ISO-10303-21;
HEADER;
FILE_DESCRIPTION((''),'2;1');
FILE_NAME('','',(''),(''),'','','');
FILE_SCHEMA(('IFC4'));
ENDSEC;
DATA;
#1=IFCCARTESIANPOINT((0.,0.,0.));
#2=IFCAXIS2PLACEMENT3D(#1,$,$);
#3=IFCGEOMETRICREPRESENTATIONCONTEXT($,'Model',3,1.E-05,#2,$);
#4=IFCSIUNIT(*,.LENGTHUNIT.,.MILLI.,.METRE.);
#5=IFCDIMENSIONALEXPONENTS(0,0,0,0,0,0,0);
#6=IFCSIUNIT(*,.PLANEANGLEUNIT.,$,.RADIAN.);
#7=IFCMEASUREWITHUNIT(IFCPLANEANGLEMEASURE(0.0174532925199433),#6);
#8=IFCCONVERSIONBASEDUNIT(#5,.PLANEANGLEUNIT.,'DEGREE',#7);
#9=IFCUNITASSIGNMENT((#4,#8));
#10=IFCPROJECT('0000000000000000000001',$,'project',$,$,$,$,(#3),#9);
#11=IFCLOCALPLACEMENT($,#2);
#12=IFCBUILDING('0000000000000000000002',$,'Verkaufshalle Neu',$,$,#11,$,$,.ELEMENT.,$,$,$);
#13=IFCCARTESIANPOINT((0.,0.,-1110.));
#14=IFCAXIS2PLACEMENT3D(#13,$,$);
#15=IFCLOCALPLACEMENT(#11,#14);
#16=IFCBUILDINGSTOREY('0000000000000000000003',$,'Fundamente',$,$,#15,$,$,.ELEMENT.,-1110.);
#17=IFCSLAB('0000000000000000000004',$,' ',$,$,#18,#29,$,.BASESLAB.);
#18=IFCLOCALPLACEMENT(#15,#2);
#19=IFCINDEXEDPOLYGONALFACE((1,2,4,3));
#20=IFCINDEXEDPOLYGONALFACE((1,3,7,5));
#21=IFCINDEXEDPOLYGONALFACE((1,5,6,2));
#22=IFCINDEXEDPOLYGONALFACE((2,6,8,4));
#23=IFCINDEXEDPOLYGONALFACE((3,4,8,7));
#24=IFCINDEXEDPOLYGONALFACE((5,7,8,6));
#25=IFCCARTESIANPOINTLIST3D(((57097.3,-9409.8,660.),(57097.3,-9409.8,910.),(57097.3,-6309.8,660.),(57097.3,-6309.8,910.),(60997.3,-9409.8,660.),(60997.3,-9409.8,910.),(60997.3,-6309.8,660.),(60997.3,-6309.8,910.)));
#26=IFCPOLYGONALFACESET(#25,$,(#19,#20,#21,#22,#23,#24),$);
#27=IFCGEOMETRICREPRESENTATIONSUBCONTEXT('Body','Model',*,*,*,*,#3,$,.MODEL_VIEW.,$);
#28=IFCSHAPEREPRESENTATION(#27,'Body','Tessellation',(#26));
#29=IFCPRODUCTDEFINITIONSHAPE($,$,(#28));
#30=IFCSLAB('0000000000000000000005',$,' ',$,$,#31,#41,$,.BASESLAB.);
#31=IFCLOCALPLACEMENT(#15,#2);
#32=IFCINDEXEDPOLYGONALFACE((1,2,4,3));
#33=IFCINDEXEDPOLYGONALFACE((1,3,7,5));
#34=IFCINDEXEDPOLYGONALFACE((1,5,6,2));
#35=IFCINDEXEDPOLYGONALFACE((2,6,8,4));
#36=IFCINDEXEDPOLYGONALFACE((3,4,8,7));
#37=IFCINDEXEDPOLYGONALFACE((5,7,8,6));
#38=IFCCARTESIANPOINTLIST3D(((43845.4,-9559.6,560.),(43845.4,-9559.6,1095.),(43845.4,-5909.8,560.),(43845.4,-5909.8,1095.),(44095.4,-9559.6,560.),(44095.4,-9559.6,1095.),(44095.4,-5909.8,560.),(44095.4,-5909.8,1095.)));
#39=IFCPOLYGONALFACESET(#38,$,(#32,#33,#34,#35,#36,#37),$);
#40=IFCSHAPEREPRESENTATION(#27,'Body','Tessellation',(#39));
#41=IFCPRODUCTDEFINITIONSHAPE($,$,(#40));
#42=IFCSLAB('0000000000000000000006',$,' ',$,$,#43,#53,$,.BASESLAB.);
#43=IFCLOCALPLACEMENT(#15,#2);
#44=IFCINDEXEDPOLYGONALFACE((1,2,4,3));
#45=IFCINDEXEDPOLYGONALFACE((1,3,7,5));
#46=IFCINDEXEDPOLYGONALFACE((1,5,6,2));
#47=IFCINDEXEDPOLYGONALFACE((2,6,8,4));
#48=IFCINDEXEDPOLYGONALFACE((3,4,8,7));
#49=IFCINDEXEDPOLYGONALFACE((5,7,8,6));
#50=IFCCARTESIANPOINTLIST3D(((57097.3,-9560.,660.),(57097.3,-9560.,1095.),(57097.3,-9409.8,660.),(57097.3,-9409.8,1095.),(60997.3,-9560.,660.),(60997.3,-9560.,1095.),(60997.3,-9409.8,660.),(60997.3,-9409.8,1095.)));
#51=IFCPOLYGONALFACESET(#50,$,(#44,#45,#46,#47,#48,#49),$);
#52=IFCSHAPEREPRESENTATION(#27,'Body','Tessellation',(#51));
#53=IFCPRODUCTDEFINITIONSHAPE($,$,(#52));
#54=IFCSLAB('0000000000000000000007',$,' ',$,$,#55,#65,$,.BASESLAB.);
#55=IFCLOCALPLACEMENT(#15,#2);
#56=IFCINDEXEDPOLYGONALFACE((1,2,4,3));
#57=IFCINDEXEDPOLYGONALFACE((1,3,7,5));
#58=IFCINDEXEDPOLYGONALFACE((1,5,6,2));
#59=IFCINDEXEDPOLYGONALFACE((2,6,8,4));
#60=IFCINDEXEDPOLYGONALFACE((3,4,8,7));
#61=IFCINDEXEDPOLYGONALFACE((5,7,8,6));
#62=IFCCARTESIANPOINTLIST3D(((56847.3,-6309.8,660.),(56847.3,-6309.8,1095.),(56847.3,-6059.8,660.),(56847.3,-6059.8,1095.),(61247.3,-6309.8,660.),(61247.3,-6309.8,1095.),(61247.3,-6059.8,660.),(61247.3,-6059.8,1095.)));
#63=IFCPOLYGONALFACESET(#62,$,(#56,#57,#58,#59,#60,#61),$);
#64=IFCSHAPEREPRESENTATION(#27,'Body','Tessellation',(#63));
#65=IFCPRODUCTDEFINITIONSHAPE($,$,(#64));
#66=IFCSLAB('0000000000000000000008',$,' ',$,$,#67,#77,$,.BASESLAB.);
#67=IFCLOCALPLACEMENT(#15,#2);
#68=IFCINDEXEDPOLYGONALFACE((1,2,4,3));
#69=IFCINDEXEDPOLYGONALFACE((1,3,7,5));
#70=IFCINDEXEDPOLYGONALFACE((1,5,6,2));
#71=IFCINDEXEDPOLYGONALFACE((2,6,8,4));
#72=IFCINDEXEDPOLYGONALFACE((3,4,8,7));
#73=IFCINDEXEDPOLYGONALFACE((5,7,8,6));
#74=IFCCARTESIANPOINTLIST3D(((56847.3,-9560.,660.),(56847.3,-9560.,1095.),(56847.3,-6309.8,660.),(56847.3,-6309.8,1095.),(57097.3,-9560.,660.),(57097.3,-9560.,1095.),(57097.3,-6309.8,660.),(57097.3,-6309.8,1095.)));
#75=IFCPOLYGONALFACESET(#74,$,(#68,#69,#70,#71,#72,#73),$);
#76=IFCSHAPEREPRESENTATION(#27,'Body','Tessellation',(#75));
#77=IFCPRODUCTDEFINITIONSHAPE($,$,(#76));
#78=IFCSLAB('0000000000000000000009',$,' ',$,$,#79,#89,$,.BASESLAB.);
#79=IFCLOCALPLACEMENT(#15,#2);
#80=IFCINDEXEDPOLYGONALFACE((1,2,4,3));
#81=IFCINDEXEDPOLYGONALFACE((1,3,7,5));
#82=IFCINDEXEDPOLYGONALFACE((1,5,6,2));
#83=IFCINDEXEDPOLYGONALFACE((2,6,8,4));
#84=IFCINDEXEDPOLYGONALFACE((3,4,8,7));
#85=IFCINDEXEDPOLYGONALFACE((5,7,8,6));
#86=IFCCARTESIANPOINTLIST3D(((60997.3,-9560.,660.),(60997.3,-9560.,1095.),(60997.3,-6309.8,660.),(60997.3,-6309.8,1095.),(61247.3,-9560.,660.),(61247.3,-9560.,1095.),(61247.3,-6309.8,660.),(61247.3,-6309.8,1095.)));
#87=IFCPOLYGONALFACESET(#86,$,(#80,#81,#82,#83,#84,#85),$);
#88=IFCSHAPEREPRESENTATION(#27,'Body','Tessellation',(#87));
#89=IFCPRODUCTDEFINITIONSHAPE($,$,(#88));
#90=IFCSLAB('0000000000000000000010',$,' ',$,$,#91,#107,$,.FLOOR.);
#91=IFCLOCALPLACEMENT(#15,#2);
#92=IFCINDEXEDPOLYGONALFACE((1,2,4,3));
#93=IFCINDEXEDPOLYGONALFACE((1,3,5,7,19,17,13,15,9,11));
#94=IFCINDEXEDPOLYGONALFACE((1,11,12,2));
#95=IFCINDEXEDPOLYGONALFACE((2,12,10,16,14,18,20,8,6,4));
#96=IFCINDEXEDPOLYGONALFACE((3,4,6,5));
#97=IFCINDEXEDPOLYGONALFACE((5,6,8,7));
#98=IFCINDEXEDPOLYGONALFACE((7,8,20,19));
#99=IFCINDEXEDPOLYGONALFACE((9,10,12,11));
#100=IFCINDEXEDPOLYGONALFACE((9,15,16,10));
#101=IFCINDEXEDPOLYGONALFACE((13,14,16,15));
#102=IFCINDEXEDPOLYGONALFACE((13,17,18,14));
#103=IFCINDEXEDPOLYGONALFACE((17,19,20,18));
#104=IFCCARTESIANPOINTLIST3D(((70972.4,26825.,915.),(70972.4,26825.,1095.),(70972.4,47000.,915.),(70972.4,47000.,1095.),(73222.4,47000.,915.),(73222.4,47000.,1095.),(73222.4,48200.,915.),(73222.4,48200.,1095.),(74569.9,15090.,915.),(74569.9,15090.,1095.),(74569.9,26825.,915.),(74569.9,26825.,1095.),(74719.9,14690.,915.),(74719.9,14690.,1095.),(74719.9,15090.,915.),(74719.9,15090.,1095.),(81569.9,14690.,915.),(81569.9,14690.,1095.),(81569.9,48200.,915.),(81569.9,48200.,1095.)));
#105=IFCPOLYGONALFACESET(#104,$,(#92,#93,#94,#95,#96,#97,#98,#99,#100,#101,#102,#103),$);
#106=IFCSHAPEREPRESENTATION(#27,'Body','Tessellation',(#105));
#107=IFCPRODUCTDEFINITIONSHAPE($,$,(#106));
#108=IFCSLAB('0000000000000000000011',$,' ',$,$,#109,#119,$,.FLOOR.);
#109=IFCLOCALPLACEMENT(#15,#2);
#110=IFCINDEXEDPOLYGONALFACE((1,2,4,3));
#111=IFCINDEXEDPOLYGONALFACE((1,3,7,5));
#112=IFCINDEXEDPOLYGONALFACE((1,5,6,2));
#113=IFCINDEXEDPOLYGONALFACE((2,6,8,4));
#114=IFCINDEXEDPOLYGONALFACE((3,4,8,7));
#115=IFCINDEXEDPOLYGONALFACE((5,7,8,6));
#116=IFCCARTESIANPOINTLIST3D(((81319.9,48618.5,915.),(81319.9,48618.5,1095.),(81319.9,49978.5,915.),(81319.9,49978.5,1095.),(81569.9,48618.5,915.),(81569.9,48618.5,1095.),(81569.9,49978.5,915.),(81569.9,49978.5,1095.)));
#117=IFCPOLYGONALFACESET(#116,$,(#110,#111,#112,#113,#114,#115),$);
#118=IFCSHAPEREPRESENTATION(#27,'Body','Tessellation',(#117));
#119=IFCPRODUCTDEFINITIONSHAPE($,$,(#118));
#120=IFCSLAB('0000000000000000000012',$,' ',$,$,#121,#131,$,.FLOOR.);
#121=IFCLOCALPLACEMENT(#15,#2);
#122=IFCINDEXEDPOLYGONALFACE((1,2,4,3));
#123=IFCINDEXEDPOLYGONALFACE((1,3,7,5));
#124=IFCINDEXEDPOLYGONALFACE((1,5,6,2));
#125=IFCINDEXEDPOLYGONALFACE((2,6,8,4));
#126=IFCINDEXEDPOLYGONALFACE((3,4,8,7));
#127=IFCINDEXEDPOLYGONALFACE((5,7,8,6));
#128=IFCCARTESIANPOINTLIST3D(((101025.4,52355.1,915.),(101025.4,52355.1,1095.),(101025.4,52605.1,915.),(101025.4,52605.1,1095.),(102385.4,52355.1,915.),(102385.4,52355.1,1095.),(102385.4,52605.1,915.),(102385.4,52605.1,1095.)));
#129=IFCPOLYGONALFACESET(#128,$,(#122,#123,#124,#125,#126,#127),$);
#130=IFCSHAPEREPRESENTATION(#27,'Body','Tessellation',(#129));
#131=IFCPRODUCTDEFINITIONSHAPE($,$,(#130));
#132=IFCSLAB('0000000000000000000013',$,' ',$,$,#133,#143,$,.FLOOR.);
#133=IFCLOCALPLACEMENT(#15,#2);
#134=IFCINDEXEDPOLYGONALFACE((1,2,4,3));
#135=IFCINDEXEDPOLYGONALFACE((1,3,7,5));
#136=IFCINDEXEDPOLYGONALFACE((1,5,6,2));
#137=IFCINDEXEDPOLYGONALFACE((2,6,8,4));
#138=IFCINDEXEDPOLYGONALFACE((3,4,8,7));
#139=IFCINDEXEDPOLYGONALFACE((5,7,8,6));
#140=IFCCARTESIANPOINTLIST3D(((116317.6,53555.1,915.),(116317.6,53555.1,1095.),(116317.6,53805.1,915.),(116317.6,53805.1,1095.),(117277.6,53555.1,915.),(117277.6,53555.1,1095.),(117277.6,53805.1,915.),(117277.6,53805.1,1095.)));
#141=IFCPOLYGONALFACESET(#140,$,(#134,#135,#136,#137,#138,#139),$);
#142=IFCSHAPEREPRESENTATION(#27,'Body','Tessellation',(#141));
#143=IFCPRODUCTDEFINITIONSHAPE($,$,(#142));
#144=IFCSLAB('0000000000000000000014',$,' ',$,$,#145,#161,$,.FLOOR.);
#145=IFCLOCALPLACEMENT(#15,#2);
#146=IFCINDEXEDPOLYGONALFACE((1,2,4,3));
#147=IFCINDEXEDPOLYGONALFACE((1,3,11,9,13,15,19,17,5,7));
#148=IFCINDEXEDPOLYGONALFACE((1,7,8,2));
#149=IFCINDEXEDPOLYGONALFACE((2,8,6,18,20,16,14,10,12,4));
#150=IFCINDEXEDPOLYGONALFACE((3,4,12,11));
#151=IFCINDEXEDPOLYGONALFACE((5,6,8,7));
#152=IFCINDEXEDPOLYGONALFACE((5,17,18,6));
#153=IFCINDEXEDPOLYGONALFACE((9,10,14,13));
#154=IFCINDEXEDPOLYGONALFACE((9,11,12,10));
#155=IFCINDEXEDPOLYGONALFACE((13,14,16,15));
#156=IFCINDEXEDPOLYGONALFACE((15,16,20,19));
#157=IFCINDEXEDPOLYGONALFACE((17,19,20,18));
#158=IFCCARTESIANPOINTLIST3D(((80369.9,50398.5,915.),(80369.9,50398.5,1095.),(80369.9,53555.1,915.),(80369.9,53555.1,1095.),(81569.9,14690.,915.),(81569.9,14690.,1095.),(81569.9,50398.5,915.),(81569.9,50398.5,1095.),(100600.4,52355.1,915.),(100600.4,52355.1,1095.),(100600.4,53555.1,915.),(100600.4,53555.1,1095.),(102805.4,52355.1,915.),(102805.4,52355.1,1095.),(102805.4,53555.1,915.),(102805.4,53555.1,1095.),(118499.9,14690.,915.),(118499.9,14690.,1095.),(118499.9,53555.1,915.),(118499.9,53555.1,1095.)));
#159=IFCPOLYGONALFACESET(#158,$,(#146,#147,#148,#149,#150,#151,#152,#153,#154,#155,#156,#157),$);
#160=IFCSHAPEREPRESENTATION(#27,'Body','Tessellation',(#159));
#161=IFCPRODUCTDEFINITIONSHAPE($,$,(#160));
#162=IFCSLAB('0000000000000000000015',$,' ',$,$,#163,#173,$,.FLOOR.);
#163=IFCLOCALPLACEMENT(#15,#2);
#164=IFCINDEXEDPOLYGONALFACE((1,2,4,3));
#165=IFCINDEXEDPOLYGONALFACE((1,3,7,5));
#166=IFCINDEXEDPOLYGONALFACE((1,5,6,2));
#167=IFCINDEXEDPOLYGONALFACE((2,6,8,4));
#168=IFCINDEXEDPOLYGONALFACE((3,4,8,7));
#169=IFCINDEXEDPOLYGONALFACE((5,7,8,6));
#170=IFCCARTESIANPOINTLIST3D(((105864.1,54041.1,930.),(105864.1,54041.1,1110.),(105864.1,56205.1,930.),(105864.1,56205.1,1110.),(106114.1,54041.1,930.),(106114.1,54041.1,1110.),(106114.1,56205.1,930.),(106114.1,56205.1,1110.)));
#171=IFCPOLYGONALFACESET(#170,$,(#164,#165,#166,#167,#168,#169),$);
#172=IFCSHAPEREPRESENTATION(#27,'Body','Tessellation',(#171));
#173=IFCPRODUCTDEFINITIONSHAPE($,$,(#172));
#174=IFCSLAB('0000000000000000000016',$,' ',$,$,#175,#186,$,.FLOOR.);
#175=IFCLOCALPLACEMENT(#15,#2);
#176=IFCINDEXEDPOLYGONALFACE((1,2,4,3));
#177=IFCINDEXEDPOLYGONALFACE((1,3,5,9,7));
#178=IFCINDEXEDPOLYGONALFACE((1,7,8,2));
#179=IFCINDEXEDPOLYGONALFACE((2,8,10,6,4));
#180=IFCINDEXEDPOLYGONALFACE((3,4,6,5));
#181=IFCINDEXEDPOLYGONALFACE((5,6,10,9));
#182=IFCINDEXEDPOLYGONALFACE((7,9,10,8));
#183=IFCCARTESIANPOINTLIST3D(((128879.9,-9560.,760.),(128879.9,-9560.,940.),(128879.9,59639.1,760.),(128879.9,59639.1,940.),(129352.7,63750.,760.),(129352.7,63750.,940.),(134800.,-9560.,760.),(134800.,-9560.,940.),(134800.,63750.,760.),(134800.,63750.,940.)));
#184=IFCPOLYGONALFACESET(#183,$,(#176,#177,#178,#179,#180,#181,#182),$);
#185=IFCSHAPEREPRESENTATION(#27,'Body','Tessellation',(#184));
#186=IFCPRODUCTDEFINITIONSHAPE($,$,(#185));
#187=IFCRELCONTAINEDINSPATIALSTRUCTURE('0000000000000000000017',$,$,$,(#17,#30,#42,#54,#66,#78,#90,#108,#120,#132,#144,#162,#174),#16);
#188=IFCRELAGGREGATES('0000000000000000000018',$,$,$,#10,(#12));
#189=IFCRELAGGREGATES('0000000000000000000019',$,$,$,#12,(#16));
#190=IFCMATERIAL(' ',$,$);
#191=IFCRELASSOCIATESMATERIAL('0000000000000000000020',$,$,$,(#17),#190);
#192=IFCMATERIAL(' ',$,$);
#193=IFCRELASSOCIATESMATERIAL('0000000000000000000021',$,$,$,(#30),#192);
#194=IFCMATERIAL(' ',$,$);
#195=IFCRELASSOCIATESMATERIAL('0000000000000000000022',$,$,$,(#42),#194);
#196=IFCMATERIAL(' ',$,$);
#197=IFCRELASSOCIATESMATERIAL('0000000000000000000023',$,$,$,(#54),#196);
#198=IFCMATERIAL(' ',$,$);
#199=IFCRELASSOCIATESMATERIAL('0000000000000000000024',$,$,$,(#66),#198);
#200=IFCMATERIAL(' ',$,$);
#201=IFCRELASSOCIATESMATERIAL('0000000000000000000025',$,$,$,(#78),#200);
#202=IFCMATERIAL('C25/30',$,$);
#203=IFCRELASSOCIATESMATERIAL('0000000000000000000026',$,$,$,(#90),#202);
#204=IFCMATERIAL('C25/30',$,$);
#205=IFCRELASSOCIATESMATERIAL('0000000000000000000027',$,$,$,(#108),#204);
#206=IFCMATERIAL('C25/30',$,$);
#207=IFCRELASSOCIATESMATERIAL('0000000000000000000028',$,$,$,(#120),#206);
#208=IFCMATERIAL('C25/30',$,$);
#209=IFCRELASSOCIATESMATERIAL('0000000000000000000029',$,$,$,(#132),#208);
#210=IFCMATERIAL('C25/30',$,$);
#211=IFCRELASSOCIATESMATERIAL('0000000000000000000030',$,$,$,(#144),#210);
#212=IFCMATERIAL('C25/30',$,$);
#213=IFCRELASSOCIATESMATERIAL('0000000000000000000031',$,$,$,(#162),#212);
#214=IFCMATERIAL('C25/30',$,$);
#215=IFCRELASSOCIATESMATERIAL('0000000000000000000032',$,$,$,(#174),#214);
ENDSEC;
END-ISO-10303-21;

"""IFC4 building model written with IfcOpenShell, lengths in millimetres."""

from ifc_helpers import new_model, entity, si_unit, converted_unit, frame, frame_2d, origin, origin_with_axes, place, context, subcontext, project, spatial, polyline, rectangle, outline, extrude, material, element, save


model = new_model("IFC4")

# Units and contexts
model_context = context("Model", 3, precision=1e-05, world=origin())
body_context = subcontext(model_context, "Body", "Model", "MODEL_VIEW")
ifc_project = project(units=[si_unit("LENGTHUNIT", "METRE", prefix="MILLI"), converted_unit("PLANEANGLEUNIT", "DEGREE", entity("IfcPlaneAngleMeasure", 0.0174532925199433), si_unit("PLANEANGLEUNIT", "RADIAN"), dimensions=[0, 0, 0, 0, 0, 0, 0])], contexts=[model_context])

# Building, storey
building_placement = place(None, origin())
building = spatial("IfcBuilding", under=ifc_project, at=building_placement, Name="Verkaufshalle Neu", CompositionType="ELEMENT")
storey_placement = place(building_placement, frame((0.0, 0.0, -1110.0)))
storey = spatial("IfcBuildingStorey", under=building, at=storey_placement, Name="Fundamente", CompositionType="ELEMENT", Elevation=-1110.0)

# Slabs
ifc_material_1 = material(Name=" ")
slab_1_placement = place(storey_placement, frame((57097.3, -9409.8, 660.0)))
element("IfcSlab", 1, at=slab_1_placement, inside=storey, material=ifc_material_1, Name=" ", PredefinedType="BASESLAB", context=body_context, shape_type="SweptSolid", body=[
    extrude(rectangle(XDim=3900.0, YDim=3100.0, at=frame_2d((1950.0, 1550.0), x_axis=(1.0, 0.0))), origin_with_axes(), (0.0, 0.0, 1.0), 250.0),
])
ifc_material_2 = material(Name=" ")
slab_2_placement = place(storey_placement, frame((43845.4, -9559.6, 560.0)))
element("IfcSlab", 2, at=slab_2_placement, inside=storey, material=ifc_material_2, Name=" ", PredefinedType="BASESLAB", context=body_context, shape_type="SweptSolid", body=[
    extrude(rectangle(XDim=3649.7, YDim=250.0, at=frame_2d((125.0, -1824.9), x_axis=(0.0, -1.0))), frame((0.0, 3649.7, 0.0), z_axis=(0.0, 0.0, 1.0), x_axis=(1.0, 0.0, 0.0)), (0.0, 0.0, 1.0), 535.0),
])
ifc_material_3 = material(Name=" ")
slab_3_placement = place(storey_placement, frame((57097.3, -9560.0, 660.0)))
element("IfcSlab", 3, at=slab_3_placement, inside=storey, material=ifc_material_3, Name=" ", PredefinedType="BASESLAB", context=body_context, shape_type="SweptSolid", body=[
    extrude(rectangle(XDim=150.2, YDim=3900.0, at=frame_2d((1950.0, -75.1), x_axis=(0.0, -1.0))), frame((0.0, 150.2, 0.0), z_axis=(0.0, 0.0, 1.0), x_axis=(1.0, 0.0, 0.0)), (0.0, 0.0, 1.0), 435.0),
])
ifc_material_4 = material(Name=" ")
slab_4_placement = place(storey_placement, frame((56847.3, -6309.8, 660.0)))
element("IfcSlab", 4, at=slab_4_placement, inside=storey, material=ifc_material_4, Name=" ", PredefinedType="BASESLAB", context=body_context, shape_type="SweptSolid", body=[
    extrude(rectangle(XDim=4400.0, YDim=250.0, at=frame_2d((2200.0, 125.0), x_axis=(1.0, 0.0))), origin_with_axes(), (0.0, 0.0, 1.0), 435.0),
])
ifc_material_5 = material(Name=" ")
slab_5_placement = place(storey_placement, frame((56847.3, -9560.0, 660.0)))
element("IfcSlab", 5, at=slab_5_placement, inside=storey, material=ifc_material_5, Name=" ", PredefinedType="BASESLAB", context=body_context, shape_type="SweptSolid", body=[
    extrude(rectangle(XDim=250.0, YDim=3250.2, at=frame_2d((125.0, 1625.1), x_axis=(1.0, 0.0))), origin_with_axes(), (0.0, 0.0, 1.0), 435.0),
])
ifc_material_6 = material(Name=" ")
slab_6_placement = place(storey_placement, frame((60997.3, -9560.0, 660.0)))
element("IfcSlab", 6, at=slab_6_placement, inside=storey, material=ifc_material_6, Name=" ", PredefinedType="BASESLAB", context=body_context, shape_type="SweptSolid", body=[
    extrude(rectangle(XDim=3250.2, YDim=250.0, at=frame_2d((125.0, -1625.1), x_axis=(0.0, -1.0))), frame((0.0, 3250.2, 0.0), z_axis=(0.0, 0.0, 1.0), x_axis=(1.0, 0.0, 0.0)), (0.0, 0.0, 1.0), 435.0),
])
ifc_material_7 = material(Name="C25/30")
slab_7_placement = place(storey_placement, frame((70972.4, 14690.0, 915.0)))
element("IfcSlab", 7, at=slab_7_placement, inside=storey, material=ifc_material_7, Name=" ", PredefinedType="FLOOR", context=body_context, shape_type="SweptSolid", body=[
    extrude(outline(polyline([(10597.5, 0.0), (10597.5, 33510.0), (2250.0, 33510.0), (2250.0, 32310.0), (0.0, 32310.0), (0.0, 12135.0), (3597.5, 12135.0), (3597.5, 400.0), (3747.5, 400.0), (3747.5, 0.0), (10597.5, 0.0)])), origin_with_axes(), (0.0, 0.0, 1.0), 180.0),
])
ifc_material_8 = material(Name="C25/30")
slab_8_placement = place(storey_placement, frame((81319.9, 48618.5, 915.0)))
element("IfcSlab", 8, at=slab_8_placement, inside=storey, material=ifc_material_8, Name=" ", PredefinedType="FLOOR", context=body_context, shape_type="SweptSolid", body=[
    extrude(rectangle(XDim=1360.0, YDim=250.0, at=frame_2d((125.0, -680.0), x_axis=(0.0, -1.0))), frame((0.0, 1360.0, 0.0), z_axis=(0.0, 0.0, 1.0), x_axis=(1.0, 0.0, 0.0)), (0.0, 0.0, 1.0), 180.0),
])
ifc_material_9 = material(Name="C25/30")
slab_9_placement = place(storey_placement, frame((101025.4, 52355.1, 915.0)))
element("IfcSlab", 9, at=slab_9_placement, inside=storey, material=ifc_material_9, Name=" ", PredefinedType="FLOOR", context=body_context, shape_type="SweptSolid", body=[
    extrude(rectangle(XDim=1360.0, YDim=250.0, at=frame_2d((680.0, 125.0), x_axis=(1.0, 0.0))), origin_with_axes(), (0.0, 0.0, 1.0), 180.0),
])
ifc_material_10 = material(Name="C25/30")
slab_10_placement = place(storey_placement, frame((116317.6, 53555.1, 915.0)))
element("IfcSlab", 10, at=slab_10_placement, inside=storey, material=ifc_material_10, Name=" ", PredefinedType="FLOOR", context=body_context, shape_type="SweptSolid", body=[
    extrude(rectangle(XDim=250.0, YDim=960.0, at=frame_2d((480.0, -125.0), x_axis=(0.0, -1.0))), frame((0.0, 250.0, 0.0), z_axis=(0.0, 0.0, 1.0), x_axis=(1.0, 0.0, 0.0)), (0.0, 0.0, 1.0), 180.0),
])
ifc_material_11 = material(Name="C25/30")
slab_11_placement = place(storey_placement, frame((80369.9, 14690.0, 915.0)))
element("IfcSlab", 11, at=slab_11_placement, inside=storey, material=ifc_material_11, Name=" ", PredefinedType="FLOOR", context=body_context, shape_type="SweptSolid", body=[
    extrude(outline(polyline([(1200.0, 0.0), (38130.0, 0.0), (38130.0, 38865.1), (22435.5, 38865.1), (22435.5, 37665.1), (20230.5, 37665.1), (20230.5, 38865.1), (0.0, 38865.1), (0.0, 35708.5), (1200.0, 35708.5), (1200.0, 0.0)])), origin_with_axes(), (0.0, 0.0, 1.0), 180.0),
])
ifc_material_12 = material(Name="C25/30")
slab_12_placement = place(storey_placement, frame((105864.1, 54041.1, 930.0)))
element("IfcSlab", 12, at=slab_12_placement, inside=storey, material=ifc_material_12, Name=" ", PredefinedType="FLOOR", context=body_context, shape_type="SweptSolid", body=[
    extrude(rectangle(XDim=2164.0, YDim=250.0, at=frame_2d((125.0, -1082.0), x_axis=(0.0, -1.0))), frame((0.0, 2164.0, 0.0), z_axis=(0.0, 0.0, 1.0), x_axis=(1.0, 0.0, 0.0)), (0.0, 0.0, 1.0), 180.0),
])
ifc_material_13 = material(Name="C25/30")
slab_13_placement = place(storey_placement, frame((128879.9, -9560.0, 760.0)))
element("IfcSlab", 13, at=slab_13_placement, inside=storey, material=ifc_material_13, Name=" ", PredefinedType="FLOOR", context=body_context, shape_type="SweptSolid", body=[
    extrude(outline(polyline([(0.0, 0.0), (5920.1, 0.0), (5920.1, 73310.0), (472.8, 73310.0), (0.0, 69199.1), (0.0, 0.0)])), origin_with_axes(), (0.0, 0.0, 1.0), 180.0),
])

save(model, "model.ifc")
